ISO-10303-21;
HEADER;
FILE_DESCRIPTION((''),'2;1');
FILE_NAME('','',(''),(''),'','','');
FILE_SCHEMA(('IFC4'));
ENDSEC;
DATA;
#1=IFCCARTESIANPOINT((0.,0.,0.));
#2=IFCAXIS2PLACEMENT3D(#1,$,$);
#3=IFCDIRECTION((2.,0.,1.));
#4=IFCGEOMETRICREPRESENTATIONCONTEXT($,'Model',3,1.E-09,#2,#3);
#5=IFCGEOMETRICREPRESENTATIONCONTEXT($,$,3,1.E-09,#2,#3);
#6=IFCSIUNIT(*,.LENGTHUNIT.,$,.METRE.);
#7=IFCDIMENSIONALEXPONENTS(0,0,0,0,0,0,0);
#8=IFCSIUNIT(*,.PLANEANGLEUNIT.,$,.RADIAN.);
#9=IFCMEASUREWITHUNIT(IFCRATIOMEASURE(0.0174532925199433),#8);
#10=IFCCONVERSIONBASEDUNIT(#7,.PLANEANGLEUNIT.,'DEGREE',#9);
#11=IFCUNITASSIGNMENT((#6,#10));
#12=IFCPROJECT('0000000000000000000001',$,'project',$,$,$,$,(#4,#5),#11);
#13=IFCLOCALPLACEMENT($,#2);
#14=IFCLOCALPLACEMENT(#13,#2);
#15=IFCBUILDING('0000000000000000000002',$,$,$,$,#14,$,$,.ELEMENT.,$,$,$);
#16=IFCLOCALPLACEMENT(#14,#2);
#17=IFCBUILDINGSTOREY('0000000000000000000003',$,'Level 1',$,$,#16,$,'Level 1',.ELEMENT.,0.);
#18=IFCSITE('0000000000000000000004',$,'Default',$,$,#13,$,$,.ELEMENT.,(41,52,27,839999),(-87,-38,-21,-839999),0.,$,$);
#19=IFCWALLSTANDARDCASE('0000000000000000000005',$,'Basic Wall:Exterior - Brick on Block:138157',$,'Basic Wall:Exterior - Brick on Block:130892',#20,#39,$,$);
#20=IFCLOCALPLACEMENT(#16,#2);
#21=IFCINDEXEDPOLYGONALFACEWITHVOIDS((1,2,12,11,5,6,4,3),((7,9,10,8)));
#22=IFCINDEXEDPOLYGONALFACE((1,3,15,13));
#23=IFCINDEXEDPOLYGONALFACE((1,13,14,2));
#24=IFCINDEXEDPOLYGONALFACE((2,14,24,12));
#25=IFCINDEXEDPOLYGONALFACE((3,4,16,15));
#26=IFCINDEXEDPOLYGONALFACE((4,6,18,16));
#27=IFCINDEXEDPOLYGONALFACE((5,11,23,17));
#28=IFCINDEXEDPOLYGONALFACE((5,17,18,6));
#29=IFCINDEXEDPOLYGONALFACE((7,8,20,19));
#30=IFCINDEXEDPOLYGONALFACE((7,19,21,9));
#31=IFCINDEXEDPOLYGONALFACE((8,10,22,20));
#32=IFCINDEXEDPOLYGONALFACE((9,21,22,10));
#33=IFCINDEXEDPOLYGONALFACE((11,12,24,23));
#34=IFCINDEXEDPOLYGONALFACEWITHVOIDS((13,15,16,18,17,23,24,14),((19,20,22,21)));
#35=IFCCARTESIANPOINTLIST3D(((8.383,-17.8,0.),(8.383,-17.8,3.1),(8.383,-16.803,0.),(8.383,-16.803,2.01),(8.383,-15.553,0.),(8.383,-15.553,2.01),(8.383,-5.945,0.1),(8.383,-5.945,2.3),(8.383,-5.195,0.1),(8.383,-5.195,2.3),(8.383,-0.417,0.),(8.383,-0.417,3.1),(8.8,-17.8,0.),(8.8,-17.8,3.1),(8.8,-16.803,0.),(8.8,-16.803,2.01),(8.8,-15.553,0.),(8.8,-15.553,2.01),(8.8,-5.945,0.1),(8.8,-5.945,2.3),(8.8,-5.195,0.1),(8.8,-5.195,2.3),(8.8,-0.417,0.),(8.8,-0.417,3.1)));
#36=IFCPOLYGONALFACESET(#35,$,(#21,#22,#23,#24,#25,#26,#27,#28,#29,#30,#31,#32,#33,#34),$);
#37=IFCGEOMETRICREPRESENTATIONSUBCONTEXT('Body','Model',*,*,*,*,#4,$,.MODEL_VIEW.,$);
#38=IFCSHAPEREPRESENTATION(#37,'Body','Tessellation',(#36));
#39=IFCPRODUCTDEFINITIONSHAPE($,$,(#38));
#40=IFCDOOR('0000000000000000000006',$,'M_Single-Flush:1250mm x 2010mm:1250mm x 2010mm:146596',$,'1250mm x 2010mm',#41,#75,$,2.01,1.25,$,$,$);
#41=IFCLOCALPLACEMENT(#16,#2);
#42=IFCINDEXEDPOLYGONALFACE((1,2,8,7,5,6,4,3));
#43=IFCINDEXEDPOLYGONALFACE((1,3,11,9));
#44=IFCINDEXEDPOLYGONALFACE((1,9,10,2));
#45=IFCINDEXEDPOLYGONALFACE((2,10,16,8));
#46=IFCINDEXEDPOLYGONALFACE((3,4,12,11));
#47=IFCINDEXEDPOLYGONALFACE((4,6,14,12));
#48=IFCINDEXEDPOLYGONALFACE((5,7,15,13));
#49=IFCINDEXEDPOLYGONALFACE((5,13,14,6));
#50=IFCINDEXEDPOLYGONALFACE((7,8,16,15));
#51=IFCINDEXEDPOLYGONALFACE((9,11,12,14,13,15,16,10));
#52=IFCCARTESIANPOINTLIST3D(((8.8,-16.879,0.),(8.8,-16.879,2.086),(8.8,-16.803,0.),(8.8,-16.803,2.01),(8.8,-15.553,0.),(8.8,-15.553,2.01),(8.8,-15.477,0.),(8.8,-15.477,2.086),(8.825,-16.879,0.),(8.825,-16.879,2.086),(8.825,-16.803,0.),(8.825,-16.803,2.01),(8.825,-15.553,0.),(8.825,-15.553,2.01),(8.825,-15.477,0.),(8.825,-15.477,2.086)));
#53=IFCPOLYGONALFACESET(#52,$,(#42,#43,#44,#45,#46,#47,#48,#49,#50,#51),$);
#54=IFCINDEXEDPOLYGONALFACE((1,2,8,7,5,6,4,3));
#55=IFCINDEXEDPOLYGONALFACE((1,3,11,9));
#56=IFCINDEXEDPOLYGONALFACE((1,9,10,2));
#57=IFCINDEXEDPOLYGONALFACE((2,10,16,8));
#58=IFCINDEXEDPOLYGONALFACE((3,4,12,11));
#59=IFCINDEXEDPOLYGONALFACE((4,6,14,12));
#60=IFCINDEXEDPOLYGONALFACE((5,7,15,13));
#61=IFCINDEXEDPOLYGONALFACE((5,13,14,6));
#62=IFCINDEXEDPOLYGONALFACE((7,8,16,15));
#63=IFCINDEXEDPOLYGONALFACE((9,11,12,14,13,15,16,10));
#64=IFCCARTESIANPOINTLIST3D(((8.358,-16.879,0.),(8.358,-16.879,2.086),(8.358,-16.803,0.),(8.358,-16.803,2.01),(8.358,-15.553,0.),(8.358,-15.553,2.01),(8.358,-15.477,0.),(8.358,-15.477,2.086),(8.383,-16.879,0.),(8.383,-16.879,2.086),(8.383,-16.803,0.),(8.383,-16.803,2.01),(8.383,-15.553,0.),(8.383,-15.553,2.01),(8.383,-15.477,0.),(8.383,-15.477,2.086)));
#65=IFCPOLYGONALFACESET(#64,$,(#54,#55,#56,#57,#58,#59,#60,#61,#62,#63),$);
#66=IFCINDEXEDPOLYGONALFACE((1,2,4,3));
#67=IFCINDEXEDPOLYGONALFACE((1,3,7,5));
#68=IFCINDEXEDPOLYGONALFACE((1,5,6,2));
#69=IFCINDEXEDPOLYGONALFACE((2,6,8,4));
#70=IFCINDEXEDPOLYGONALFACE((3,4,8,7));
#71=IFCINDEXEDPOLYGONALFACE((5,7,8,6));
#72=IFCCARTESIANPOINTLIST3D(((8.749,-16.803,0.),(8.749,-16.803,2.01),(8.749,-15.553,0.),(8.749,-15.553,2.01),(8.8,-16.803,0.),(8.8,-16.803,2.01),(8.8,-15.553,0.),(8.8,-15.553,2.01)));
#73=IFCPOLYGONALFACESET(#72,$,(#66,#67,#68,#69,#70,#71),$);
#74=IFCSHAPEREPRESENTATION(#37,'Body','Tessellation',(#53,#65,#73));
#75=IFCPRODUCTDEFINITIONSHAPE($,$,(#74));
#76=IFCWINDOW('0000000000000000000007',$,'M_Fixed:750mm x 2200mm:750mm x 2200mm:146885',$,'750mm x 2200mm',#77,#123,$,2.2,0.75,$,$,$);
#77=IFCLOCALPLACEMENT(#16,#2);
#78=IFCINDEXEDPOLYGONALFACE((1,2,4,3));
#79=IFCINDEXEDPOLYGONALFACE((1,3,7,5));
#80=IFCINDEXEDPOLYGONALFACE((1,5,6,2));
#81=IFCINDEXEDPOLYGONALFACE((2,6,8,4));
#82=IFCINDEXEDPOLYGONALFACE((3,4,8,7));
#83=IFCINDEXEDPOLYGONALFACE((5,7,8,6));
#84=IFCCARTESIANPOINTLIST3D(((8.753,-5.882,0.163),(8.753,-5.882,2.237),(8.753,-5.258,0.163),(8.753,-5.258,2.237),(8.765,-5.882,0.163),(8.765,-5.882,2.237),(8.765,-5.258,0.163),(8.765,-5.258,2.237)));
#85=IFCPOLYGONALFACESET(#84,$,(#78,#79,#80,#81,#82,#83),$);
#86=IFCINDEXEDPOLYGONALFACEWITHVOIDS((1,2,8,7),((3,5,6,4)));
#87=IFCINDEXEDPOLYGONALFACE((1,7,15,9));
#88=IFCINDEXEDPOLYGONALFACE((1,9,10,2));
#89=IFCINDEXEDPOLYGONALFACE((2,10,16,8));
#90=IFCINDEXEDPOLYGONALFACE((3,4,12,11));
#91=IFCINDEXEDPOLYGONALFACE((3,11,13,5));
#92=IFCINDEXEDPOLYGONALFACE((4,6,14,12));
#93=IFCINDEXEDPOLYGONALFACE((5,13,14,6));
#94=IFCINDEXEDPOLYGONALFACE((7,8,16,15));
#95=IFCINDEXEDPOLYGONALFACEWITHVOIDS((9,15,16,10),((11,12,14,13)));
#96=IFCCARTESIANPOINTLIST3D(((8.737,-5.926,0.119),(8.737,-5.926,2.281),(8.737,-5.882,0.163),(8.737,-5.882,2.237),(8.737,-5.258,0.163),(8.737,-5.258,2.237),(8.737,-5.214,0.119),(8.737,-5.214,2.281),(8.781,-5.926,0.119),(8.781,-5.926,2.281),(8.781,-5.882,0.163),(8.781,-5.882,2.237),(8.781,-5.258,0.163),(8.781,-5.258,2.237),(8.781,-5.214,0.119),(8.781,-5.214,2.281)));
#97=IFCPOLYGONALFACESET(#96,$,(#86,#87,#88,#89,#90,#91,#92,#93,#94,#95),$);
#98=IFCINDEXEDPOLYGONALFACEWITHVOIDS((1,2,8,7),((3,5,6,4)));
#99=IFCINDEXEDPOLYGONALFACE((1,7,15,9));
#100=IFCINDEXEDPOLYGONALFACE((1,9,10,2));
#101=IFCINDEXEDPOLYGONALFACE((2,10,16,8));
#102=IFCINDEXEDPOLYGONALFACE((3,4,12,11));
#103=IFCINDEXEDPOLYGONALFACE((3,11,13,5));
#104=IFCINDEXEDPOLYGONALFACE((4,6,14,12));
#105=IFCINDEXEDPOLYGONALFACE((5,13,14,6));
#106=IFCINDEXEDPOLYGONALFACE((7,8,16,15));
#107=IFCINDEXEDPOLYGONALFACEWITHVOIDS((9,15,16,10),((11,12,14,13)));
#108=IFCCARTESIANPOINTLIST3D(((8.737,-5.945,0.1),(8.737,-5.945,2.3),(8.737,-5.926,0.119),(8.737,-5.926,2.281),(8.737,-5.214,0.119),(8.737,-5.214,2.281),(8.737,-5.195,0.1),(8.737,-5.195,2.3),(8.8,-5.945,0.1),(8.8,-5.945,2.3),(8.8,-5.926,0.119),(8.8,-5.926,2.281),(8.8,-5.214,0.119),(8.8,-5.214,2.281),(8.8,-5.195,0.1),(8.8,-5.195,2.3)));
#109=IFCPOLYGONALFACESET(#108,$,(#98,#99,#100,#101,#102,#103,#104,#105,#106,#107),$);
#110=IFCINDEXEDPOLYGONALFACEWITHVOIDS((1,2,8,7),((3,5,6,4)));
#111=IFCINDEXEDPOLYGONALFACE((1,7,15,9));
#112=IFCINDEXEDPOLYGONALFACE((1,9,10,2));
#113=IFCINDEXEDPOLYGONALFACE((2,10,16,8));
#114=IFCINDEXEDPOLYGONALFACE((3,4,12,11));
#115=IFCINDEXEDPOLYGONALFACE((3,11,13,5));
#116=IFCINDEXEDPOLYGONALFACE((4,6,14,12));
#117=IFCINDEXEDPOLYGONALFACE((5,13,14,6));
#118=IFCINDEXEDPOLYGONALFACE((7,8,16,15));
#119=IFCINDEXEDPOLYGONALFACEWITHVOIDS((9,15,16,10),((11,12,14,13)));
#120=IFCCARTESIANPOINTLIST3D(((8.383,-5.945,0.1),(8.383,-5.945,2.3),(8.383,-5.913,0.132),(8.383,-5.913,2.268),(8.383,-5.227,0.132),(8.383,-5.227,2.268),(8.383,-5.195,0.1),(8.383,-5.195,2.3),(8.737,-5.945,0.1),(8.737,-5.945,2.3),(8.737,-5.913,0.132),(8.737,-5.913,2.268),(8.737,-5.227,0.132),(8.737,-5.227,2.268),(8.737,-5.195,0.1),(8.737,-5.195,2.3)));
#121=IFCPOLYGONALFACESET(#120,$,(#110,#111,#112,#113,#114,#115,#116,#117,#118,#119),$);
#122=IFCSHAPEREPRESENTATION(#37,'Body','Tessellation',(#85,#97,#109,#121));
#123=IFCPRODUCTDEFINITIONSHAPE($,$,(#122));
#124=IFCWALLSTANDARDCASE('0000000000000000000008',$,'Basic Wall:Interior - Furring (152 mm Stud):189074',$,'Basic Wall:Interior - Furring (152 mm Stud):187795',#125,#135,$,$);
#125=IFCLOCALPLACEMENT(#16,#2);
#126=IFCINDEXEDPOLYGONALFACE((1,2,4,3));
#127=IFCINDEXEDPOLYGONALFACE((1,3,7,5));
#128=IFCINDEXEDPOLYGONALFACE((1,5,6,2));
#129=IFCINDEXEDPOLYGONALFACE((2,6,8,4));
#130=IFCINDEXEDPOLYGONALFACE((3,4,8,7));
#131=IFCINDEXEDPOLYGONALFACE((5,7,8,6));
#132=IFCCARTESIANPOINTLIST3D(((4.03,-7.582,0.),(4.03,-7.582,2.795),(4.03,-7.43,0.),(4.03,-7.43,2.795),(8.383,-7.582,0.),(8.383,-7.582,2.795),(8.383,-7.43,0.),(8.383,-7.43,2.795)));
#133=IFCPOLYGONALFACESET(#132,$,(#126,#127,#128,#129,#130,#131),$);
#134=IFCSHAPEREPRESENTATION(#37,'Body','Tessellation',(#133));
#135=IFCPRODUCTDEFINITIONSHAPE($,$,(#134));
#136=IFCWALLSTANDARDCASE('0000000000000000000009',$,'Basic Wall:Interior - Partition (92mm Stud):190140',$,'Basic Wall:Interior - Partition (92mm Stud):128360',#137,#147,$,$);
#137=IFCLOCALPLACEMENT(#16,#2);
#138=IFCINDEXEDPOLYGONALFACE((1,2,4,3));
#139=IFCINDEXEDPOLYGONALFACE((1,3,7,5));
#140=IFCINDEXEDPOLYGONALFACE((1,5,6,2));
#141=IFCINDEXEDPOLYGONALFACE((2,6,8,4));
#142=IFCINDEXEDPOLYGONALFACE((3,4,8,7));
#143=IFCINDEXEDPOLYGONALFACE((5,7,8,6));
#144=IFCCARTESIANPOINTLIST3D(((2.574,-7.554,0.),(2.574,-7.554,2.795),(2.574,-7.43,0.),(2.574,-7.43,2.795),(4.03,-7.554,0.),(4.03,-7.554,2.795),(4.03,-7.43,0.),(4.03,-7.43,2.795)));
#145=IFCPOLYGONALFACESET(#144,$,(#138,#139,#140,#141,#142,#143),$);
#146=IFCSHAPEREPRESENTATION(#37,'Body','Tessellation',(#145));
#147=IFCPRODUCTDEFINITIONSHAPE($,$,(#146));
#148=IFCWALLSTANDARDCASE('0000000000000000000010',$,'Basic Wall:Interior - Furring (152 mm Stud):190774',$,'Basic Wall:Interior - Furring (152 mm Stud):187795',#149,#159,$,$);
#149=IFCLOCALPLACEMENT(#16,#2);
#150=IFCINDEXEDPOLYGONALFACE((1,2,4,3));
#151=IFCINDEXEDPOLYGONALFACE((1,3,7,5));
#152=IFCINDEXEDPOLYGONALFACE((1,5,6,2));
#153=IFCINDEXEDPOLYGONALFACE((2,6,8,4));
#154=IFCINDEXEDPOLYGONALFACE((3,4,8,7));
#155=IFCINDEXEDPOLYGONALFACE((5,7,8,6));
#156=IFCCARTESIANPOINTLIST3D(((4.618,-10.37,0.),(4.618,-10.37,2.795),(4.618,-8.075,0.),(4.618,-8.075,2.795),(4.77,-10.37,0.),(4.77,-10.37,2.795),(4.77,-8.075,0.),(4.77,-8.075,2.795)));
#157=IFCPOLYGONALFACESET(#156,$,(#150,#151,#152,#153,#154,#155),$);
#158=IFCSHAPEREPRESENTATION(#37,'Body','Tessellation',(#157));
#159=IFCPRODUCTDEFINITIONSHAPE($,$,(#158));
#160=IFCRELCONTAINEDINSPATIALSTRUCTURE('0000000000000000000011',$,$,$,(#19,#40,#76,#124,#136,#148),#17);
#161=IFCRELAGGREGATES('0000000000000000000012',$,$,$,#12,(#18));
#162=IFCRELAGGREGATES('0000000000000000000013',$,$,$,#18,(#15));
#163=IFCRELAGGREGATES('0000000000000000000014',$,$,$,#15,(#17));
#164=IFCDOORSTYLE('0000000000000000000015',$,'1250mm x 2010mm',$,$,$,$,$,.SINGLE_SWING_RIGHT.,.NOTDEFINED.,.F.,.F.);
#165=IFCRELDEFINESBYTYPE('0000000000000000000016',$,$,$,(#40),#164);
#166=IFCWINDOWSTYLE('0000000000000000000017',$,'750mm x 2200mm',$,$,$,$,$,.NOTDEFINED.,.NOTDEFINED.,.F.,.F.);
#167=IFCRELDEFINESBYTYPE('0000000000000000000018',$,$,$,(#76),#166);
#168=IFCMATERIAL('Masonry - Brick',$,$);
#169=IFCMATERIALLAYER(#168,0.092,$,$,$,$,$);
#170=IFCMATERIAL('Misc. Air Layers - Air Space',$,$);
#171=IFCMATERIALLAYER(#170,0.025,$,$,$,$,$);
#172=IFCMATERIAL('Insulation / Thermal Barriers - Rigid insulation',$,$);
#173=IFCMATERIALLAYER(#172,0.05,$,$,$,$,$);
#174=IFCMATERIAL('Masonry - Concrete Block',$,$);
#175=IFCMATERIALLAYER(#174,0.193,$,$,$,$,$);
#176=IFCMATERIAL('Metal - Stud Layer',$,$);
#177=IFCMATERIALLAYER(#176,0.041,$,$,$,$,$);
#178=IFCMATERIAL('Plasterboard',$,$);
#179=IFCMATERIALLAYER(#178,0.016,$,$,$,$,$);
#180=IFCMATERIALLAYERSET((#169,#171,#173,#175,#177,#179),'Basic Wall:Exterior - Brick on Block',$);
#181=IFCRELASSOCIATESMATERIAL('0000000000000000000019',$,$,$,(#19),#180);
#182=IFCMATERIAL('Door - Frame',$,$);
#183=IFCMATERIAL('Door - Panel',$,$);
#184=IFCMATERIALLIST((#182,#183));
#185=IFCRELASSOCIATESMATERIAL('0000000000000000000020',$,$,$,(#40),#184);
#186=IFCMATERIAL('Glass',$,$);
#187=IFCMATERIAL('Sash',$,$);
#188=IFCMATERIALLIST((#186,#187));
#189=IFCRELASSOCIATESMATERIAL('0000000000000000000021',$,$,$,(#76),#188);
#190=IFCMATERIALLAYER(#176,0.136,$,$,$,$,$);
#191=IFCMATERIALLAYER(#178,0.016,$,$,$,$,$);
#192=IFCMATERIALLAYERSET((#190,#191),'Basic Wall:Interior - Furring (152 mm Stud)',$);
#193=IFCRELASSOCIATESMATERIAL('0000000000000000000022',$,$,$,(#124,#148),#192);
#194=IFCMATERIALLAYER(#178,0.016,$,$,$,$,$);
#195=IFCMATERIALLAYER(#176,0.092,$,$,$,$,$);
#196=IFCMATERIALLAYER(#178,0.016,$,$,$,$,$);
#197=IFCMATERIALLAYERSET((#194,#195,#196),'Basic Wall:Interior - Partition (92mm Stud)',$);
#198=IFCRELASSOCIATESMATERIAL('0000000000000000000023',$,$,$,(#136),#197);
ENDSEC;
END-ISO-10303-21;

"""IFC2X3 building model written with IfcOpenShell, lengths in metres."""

from ifc_helpers import new_model, entity, si_unit, converted_unit, direction, frame, frame_2d, origin, origin_2d_with_axis, place, context, subcontext, project, spatial, polyline, rectangle, outline, extrude, clip, bounded_halfspace, source, transform, mapped, material, material_list, layer, layer_set, layer_usage, type_object, type_shapes, element, fill, save


model = new_model("IFC2X3")

# Units and contexts
model_context = context("Model", 3, precision=1e-09, world=origin(), true_north=direction((2.0, 0.0, 1.0)))
context_of_model = context(None, 3, precision=1e-09, world=origin(), true_north=direction((2.0, 0.0, 1.0)))
body_context = subcontext(model_context, "Body", "Model", "MODEL_VIEW")
ifc_project = project(units=[si_unit("LENGTHUNIT", "METRE"), converted_unit("PLANEANGLEUNIT", "DEGREE", entity("IfcRatioMeasure", 0.0174532925199433), si_unit("PLANEANGLEUNIT", "RADIAN"), dimensions=[0, 0, 0, 0, 0, 0, 0])], contexts=[model_context, context_of_model])

# Site, building, storey
site_placement = place(None, origin())
site = spatial("IfcSite", under=ifc_project, at=site_placement, Name="Default", CompositionType="ELEMENT", RefLatitude=(41, 52, 27, 839999), RefLongitude=(-87, -38, -21, -839999), RefElevation=0.0)
building_placement = place(site_placement, origin())
building = spatial("IfcBuilding", under=site, at=building_placement, CompositionType="ELEMENT")
storey_placement = place(building_placement, origin())
storey = spatial("IfcBuildingStorey", under=building, at=storey_placement, Name="Level 1", LongName="Level 1", CompositionType="ELEMENT", Elevation=0.0)

# Wall, openings, door, window
ifc_material_1 = material(Name="Masonry - Brick")
ifc_layer_1 = layer(ifc_material_1, 0.092)
ifc_material_2 = material(Name="Misc. Air Layers - Air Space")
ifc_layer_2 = layer(ifc_material_2, 0.025)
ifc_material_3 = material(Name="Insulation / Thermal Barriers - Rigid insulation")
ifc_layer_3 = layer(ifc_material_3, 0.05)
ifc_material_4 = material(Name="Masonry - Concrete Block")
ifc_layer_4 = layer(ifc_material_4, 0.193)
ifc_material_5 = material(Name="Metal - Stud Layer")
ifc_layer_5 = layer(ifc_material_5, 0.041)
ifc_material_6 = material(Name="Plasterboard")
ifc_layer_6 = layer(ifc_material_6, 0.016)
ifc_layer_set_1 = layer_set([ifc_layer_1, ifc_layer_2, ifc_layer_3, ifc_layer_4, ifc_layer_5, ifc_layer_6], Name="Basic Wall:Exterior - Brick on Block")
ifc_layer_usage_1 = layer_usage(ifc_layer_set_1, "AXIS2", "NEGATIVE", 0.2085)
wall_1_placement = place(storey_placement, frame((8.5915, -0.417, 0.0), z_axis=(0.0, 0.0, 1.0), x_axis=(0.0, -1.0, 0.0)))
wall_1 = element("IfcWallStandardCase", 1, at=wall_1_placement, inside=storey, material=ifc_layer_usage_1, Name="Basic Wall:Exterior - Brick on Block:138157", ObjectType="Basic Wall:Exterior - Brick on Block:130892", context=body_context, shape_type="SweptSolid", body=[
    extrude(rectangle(XDim=17.383, YDim=0.417, at=frame_2d((8.6915, 0.0), x_axis=(-1.0, 0.0))), origin(), (0.0, 0.0, 1.0), 3.1),
])
opening_1_placement = place(wall_1_placement, frame((15.136, -0.2085, 0.0)))
opening_1 = element("IfcOpeningElement", 2, at=opening_1_placement, cuts=wall_1, ObjectType="Opening", context=body_context, shape_type="SweptSolid", body=[
    extrude(rectangle(XDim=1.25, YDim=2.01, at=frame_2d((1.005, 0.625), x_axis=(0.0, 1.0))), frame((0.0, 0.0, 0.0), z_axis=(0.0, 1.0, 0.0), x_axis=(0.0, 0.0, 1.0)), (0.0, 0.0, 1.0), 0.417),
])
opening_2_placement = place(wall_1_placement, frame((4.778, -0.2085, 0.1)))
opening_2 = element("IfcOpeningElement", 3, at=opening_2_placement, cuts=wall_1, ObjectType="Opening", context=body_context, shape_type="SweptSolid", body=[
    extrude(rectangle(XDim=2.2, YDim=0.75, at=frame_2d((1.1, 0.375), x_axis=(1.0, 0.0))), frame((0.0, 0.0, 0.0), z_axis=(0.0, 1.0, 0.0), x_axis=(0.0, 0.0, 1.0)), (0.0, 0.0, 1.0), 0.417),
])
ifc_material_7 = material(Name="Door - Frame")
ifc_material_8 = material(Name="Door - Panel")
ifc_material_list_1 = material_list([ifc_material_7, ifc_material_8])
door_style = type_object("IfcDoorStyle", Name="1250mm x 2010mm", ConstructionType="NOTDEFINED", OperationType="SINGLE_SWING_RIGHT", ParameterTakesPrecedence=False, Sizeable=False)
shared_shape_1 = source(origin(), body_context, "Body", "SweptSolid", [
    extrude(outline(polyline([(-0.701, -1.062), (0.701, -1.062), (0.701, 1.024), (0.625, 1.024), (0.625, -0.986), (-0.625, -0.986), (-0.625, 1.024), (-0.701, 1.024), (-0.701, -1.062)])), frame((0.625, 0.417, 1.024), z_axis=(0.0, 1.0, 0.0), x_axis=(1.0, 0.0, 0.0)), (0.0, 0.0, 1.0), 0.025),
    extrude(outline(polyline([(-1.062, -0.701), (1.024, -0.701), (1.024, -0.625), (-0.986, -0.625), (-0.986, 0.625), (1.024, 0.625), (1.024, 0.701), (-1.062, 0.701), (-1.062, -0.701)])), frame((0.625, -0.025, 1.024), z_axis=(0.0, 1.0, 0.0), x_axis=(0.0, 0.0, -1.0)), (0.0, 0.0, 1.0), 0.025),
    extrude(rectangle(XDim=0.051, YDim=1.25, at=frame_2d((0.0, 0.0), x_axis=(1.0, 0.0))), frame((0.625, 0.3915, 0.0), z_axis=(0.0, 0.0, 1.0), x_axis=(0.0, 1.0, 0.0)), (0.0, 0.0, 1.0), 2.01),
])
type_shapes(door_style, [shared_shape_1])
door_placement = place(opening_1_placement, origin())
door = element("IfcDoor", 4, at=door_placement, inside=storey, type_object=door_style, material=ifc_material_list_1, Name="M_Single-Flush:1250mm x 2010mm:1250mm x 2010mm:146596", ObjectType="1250mm x 2010mm", OverallHeight=2.01, OverallWidth=1.25, context=body_context, shape_type="MappedRepresentation", body=[
    mapped(shared_shape_1, transform((0.0, 0.0, 0.0), scale=1.0)),
])
fill(opening_1, door)
ifc_material_9 = material(Name="Glass")
ifc_material_10 = material(Name="Sash")
ifc_material_list_2 = material_list([ifc_material_9, ifc_material_10])
window_style = type_object("IfcWindowStyle", Name="750mm x 2200mm", ConstructionType="NOTDEFINED", OperationType="NOTDEFINED", ParameterTakesPrecedence=False, Sizeable=False)
shared_shape_2 = source(origin(), body_context, "Body", "SweptSolid", [
    extrude(rectangle(XDim=0.012, YDim=0.624, at=origin_2d_with_axis()), frame((0.375, 0.376, 0.063), z_axis=(0.0, 0.0, 1.0), x_axis=(0.0, -1.0, 0.0)), (0.0, 0.0, 1.0), 2.074),
    extrude(outline(polyline([(-0.356, -1.081), (0.356, -1.081), (0.356, 1.081), (-0.356, 1.081), (-0.356, -1.081)]), holes=[polyline([(-0.312, -1.037), (-0.312, 1.037), (0.312, 1.037), (0.312, -1.037), (-0.312, -1.037)])]), frame((0.375, 0.354, 1.1), z_axis=(0.0, 1.0, 0.0), x_axis=(1.0, 0.0, 0.0)), (0.0, 0.0, 1.0), 0.044),
    extrude(outline(polyline([(-0.375, -1.1), (0.375, -1.1), (0.375, 1.1), (-0.375, 1.1), (-0.375, -1.1)]), holes=[polyline([(-0.356, -1.081), (-0.356, 1.081), (0.356, 1.081), (0.356, -1.081), (-0.356, -1.081)])]), frame((0.375, 0.354, 1.1), z_axis=(0.0, 1.0, 0.0), x_axis=(1.0, 0.0, 0.0)), (0.0, 0.0, 1.0), 0.063),
    extrude(outline(polyline([(-0.375, -1.1), (0.375, -1.1), (0.375, 1.1), (-0.375, 1.1), (-0.375, -1.1)]), holes=[polyline([(-0.343, -1.068), (-0.343, 1.068), (0.343, 1.068), (0.343, -1.068), (-0.343, -1.068)])]), frame((0.375, 0.0, 1.1), z_axis=(0.0, 1.0, 0.0), x_axis=(1.0, 0.0, 0.0)), (0.0, 0.0, 1.0), 0.354),
])
type_shapes(window_style, [shared_shape_2])
window_placement = place(opening_2_placement, origin())
window = element("IfcWindow", 5, at=window_placement, inside=storey, type_object=window_style, material=ifc_material_list_2, Name="M_Fixed:750mm x 2200mm:750mm x 2200mm:146885", ObjectType="750mm x 2200mm", OverallHeight=2.2, OverallWidth=0.75, context=body_context, shape_type="MappedRepresentation", body=[
    mapped(shared_shape_2, transform((0.0, 0.0, 0.0), scale=1.0)),
])
fill(opening_2, window)

# Walls
ifc_layer_7 = layer(ifc_material_5, 0.136)
ifc_layer_8 = layer(ifc_material_6, 0.016)
ifc_layer_set_2 = layer_set([ifc_layer_7, ifc_layer_8], Name="Basic Wall:Interior - Furring (152 mm Stud)")
ifc_layer_usage_2 = layer_usage(ifc_layer_set_2, "AXIS2", "NEGATIVE", 0.076)
wall_2_placement = place(storey_placement, frame((8.383, -7.506, 0.0), z_axis=(0.0, 0.0, 1.0), x_axis=(-1.0, 0.0, 0.0)))
element("IfcWallStandardCase", 6, at=wall_2_placement, inside=storey, material=ifc_layer_usage_2, Name="Basic Wall:Interior - Furring (152 mm Stud):189074", ObjectType="Basic Wall:Interior - Furring (152 mm Stud):187795", context=body_context, shape_type="Clipping", body=[
    clip(extrude(rectangle(XDim=4.353, YDim=0.152, at=frame_2d((2.1765, 0.0), x_axis=(-1.0, 0.0))), origin(), (0.0, 0.0, 1.0), 2.795), bounded_halfspace(frame((0.0, -0.076, 2.795), z_axis=(0.0, 0.0, -1.0), x_axis=(0.0, 1.0, 0.0)), True, frame((0.0, -0.076, 2.795)), polyline([(0.0, 0.0), (3.708, 0.0), (3.708, 0.152), (0.0, 0.152), (0.0, 0.0)]))),
])
ifc_layer_9 = layer(ifc_material_6, 0.016)
ifc_layer_10 = layer(ifc_material_5, 0.092)
ifc_layer_11 = layer(ifc_material_6, 0.016)
ifc_layer_set_3 = layer_set([ifc_layer_9, ifc_layer_10, ifc_layer_11], Name="Basic Wall:Interior - Partition (92mm Stud)")
ifc_layer_usage_3 = layer_usage(ifc_layer_set_3, "AXIS2", "NEGATIVE", 0.062)
wall_3_placement = place(storey_placement, frame((4.03, -7.492, 0.0), z_axis=(0.0, 0.0, 1.0), x_axis=(-1.0, 0.0, 0.0)))
element("IfcWallStandardCase", 7, at=wall_3_placement, inside=storey, material=ifc_layer_usage_3, Name="Basic Wall:Interior - Partition (92mm Stud):190140", ObjectType="Basic Wall:Interior - Partition (92mm Stud):128360", context=body_context, shape_type="SweptSolid", body=[
    extrude(rectangle(XDim=1.456, YDim=0.124, at=frame_2d((0.728, 0.0), x_axis=(-1.0, 0.0))), origin(), (0.0, 0.0, 1.0), 2.795),
])
ifc_layer_usage_4 = layer_usage(ifc_layer_set_2, "AXIS2", "POSITIVE", -0.076)
wall_4_placement = place(storey_placement, frame((4.694, -8.075, 0.0), z_axis=(0.0, 0.0, 1.0), x_axis=(0.0, -1.0, 0.0)))
element("IfcWallStandardCase", 8, at=wall_4_placement, inside=storey, material=ifc_layer_usage_4, Name="Basic Wall:Interior - Furring (152 mm Stud):190774", ObjectType="Basic Wall:Interior - Furring (152 mm Stud):187795", context=body_context, shape_type="SweptSolid", body=[
    extrude(rectangle(XDim=2.295, YDim=0.152, at=frame_2d((1.1475, 0.0), x_axis=(-1.0, 0.0))), origin(), (0.0, 0.0, 1.0), 2.795),
])

save(model, "model.ifc")
